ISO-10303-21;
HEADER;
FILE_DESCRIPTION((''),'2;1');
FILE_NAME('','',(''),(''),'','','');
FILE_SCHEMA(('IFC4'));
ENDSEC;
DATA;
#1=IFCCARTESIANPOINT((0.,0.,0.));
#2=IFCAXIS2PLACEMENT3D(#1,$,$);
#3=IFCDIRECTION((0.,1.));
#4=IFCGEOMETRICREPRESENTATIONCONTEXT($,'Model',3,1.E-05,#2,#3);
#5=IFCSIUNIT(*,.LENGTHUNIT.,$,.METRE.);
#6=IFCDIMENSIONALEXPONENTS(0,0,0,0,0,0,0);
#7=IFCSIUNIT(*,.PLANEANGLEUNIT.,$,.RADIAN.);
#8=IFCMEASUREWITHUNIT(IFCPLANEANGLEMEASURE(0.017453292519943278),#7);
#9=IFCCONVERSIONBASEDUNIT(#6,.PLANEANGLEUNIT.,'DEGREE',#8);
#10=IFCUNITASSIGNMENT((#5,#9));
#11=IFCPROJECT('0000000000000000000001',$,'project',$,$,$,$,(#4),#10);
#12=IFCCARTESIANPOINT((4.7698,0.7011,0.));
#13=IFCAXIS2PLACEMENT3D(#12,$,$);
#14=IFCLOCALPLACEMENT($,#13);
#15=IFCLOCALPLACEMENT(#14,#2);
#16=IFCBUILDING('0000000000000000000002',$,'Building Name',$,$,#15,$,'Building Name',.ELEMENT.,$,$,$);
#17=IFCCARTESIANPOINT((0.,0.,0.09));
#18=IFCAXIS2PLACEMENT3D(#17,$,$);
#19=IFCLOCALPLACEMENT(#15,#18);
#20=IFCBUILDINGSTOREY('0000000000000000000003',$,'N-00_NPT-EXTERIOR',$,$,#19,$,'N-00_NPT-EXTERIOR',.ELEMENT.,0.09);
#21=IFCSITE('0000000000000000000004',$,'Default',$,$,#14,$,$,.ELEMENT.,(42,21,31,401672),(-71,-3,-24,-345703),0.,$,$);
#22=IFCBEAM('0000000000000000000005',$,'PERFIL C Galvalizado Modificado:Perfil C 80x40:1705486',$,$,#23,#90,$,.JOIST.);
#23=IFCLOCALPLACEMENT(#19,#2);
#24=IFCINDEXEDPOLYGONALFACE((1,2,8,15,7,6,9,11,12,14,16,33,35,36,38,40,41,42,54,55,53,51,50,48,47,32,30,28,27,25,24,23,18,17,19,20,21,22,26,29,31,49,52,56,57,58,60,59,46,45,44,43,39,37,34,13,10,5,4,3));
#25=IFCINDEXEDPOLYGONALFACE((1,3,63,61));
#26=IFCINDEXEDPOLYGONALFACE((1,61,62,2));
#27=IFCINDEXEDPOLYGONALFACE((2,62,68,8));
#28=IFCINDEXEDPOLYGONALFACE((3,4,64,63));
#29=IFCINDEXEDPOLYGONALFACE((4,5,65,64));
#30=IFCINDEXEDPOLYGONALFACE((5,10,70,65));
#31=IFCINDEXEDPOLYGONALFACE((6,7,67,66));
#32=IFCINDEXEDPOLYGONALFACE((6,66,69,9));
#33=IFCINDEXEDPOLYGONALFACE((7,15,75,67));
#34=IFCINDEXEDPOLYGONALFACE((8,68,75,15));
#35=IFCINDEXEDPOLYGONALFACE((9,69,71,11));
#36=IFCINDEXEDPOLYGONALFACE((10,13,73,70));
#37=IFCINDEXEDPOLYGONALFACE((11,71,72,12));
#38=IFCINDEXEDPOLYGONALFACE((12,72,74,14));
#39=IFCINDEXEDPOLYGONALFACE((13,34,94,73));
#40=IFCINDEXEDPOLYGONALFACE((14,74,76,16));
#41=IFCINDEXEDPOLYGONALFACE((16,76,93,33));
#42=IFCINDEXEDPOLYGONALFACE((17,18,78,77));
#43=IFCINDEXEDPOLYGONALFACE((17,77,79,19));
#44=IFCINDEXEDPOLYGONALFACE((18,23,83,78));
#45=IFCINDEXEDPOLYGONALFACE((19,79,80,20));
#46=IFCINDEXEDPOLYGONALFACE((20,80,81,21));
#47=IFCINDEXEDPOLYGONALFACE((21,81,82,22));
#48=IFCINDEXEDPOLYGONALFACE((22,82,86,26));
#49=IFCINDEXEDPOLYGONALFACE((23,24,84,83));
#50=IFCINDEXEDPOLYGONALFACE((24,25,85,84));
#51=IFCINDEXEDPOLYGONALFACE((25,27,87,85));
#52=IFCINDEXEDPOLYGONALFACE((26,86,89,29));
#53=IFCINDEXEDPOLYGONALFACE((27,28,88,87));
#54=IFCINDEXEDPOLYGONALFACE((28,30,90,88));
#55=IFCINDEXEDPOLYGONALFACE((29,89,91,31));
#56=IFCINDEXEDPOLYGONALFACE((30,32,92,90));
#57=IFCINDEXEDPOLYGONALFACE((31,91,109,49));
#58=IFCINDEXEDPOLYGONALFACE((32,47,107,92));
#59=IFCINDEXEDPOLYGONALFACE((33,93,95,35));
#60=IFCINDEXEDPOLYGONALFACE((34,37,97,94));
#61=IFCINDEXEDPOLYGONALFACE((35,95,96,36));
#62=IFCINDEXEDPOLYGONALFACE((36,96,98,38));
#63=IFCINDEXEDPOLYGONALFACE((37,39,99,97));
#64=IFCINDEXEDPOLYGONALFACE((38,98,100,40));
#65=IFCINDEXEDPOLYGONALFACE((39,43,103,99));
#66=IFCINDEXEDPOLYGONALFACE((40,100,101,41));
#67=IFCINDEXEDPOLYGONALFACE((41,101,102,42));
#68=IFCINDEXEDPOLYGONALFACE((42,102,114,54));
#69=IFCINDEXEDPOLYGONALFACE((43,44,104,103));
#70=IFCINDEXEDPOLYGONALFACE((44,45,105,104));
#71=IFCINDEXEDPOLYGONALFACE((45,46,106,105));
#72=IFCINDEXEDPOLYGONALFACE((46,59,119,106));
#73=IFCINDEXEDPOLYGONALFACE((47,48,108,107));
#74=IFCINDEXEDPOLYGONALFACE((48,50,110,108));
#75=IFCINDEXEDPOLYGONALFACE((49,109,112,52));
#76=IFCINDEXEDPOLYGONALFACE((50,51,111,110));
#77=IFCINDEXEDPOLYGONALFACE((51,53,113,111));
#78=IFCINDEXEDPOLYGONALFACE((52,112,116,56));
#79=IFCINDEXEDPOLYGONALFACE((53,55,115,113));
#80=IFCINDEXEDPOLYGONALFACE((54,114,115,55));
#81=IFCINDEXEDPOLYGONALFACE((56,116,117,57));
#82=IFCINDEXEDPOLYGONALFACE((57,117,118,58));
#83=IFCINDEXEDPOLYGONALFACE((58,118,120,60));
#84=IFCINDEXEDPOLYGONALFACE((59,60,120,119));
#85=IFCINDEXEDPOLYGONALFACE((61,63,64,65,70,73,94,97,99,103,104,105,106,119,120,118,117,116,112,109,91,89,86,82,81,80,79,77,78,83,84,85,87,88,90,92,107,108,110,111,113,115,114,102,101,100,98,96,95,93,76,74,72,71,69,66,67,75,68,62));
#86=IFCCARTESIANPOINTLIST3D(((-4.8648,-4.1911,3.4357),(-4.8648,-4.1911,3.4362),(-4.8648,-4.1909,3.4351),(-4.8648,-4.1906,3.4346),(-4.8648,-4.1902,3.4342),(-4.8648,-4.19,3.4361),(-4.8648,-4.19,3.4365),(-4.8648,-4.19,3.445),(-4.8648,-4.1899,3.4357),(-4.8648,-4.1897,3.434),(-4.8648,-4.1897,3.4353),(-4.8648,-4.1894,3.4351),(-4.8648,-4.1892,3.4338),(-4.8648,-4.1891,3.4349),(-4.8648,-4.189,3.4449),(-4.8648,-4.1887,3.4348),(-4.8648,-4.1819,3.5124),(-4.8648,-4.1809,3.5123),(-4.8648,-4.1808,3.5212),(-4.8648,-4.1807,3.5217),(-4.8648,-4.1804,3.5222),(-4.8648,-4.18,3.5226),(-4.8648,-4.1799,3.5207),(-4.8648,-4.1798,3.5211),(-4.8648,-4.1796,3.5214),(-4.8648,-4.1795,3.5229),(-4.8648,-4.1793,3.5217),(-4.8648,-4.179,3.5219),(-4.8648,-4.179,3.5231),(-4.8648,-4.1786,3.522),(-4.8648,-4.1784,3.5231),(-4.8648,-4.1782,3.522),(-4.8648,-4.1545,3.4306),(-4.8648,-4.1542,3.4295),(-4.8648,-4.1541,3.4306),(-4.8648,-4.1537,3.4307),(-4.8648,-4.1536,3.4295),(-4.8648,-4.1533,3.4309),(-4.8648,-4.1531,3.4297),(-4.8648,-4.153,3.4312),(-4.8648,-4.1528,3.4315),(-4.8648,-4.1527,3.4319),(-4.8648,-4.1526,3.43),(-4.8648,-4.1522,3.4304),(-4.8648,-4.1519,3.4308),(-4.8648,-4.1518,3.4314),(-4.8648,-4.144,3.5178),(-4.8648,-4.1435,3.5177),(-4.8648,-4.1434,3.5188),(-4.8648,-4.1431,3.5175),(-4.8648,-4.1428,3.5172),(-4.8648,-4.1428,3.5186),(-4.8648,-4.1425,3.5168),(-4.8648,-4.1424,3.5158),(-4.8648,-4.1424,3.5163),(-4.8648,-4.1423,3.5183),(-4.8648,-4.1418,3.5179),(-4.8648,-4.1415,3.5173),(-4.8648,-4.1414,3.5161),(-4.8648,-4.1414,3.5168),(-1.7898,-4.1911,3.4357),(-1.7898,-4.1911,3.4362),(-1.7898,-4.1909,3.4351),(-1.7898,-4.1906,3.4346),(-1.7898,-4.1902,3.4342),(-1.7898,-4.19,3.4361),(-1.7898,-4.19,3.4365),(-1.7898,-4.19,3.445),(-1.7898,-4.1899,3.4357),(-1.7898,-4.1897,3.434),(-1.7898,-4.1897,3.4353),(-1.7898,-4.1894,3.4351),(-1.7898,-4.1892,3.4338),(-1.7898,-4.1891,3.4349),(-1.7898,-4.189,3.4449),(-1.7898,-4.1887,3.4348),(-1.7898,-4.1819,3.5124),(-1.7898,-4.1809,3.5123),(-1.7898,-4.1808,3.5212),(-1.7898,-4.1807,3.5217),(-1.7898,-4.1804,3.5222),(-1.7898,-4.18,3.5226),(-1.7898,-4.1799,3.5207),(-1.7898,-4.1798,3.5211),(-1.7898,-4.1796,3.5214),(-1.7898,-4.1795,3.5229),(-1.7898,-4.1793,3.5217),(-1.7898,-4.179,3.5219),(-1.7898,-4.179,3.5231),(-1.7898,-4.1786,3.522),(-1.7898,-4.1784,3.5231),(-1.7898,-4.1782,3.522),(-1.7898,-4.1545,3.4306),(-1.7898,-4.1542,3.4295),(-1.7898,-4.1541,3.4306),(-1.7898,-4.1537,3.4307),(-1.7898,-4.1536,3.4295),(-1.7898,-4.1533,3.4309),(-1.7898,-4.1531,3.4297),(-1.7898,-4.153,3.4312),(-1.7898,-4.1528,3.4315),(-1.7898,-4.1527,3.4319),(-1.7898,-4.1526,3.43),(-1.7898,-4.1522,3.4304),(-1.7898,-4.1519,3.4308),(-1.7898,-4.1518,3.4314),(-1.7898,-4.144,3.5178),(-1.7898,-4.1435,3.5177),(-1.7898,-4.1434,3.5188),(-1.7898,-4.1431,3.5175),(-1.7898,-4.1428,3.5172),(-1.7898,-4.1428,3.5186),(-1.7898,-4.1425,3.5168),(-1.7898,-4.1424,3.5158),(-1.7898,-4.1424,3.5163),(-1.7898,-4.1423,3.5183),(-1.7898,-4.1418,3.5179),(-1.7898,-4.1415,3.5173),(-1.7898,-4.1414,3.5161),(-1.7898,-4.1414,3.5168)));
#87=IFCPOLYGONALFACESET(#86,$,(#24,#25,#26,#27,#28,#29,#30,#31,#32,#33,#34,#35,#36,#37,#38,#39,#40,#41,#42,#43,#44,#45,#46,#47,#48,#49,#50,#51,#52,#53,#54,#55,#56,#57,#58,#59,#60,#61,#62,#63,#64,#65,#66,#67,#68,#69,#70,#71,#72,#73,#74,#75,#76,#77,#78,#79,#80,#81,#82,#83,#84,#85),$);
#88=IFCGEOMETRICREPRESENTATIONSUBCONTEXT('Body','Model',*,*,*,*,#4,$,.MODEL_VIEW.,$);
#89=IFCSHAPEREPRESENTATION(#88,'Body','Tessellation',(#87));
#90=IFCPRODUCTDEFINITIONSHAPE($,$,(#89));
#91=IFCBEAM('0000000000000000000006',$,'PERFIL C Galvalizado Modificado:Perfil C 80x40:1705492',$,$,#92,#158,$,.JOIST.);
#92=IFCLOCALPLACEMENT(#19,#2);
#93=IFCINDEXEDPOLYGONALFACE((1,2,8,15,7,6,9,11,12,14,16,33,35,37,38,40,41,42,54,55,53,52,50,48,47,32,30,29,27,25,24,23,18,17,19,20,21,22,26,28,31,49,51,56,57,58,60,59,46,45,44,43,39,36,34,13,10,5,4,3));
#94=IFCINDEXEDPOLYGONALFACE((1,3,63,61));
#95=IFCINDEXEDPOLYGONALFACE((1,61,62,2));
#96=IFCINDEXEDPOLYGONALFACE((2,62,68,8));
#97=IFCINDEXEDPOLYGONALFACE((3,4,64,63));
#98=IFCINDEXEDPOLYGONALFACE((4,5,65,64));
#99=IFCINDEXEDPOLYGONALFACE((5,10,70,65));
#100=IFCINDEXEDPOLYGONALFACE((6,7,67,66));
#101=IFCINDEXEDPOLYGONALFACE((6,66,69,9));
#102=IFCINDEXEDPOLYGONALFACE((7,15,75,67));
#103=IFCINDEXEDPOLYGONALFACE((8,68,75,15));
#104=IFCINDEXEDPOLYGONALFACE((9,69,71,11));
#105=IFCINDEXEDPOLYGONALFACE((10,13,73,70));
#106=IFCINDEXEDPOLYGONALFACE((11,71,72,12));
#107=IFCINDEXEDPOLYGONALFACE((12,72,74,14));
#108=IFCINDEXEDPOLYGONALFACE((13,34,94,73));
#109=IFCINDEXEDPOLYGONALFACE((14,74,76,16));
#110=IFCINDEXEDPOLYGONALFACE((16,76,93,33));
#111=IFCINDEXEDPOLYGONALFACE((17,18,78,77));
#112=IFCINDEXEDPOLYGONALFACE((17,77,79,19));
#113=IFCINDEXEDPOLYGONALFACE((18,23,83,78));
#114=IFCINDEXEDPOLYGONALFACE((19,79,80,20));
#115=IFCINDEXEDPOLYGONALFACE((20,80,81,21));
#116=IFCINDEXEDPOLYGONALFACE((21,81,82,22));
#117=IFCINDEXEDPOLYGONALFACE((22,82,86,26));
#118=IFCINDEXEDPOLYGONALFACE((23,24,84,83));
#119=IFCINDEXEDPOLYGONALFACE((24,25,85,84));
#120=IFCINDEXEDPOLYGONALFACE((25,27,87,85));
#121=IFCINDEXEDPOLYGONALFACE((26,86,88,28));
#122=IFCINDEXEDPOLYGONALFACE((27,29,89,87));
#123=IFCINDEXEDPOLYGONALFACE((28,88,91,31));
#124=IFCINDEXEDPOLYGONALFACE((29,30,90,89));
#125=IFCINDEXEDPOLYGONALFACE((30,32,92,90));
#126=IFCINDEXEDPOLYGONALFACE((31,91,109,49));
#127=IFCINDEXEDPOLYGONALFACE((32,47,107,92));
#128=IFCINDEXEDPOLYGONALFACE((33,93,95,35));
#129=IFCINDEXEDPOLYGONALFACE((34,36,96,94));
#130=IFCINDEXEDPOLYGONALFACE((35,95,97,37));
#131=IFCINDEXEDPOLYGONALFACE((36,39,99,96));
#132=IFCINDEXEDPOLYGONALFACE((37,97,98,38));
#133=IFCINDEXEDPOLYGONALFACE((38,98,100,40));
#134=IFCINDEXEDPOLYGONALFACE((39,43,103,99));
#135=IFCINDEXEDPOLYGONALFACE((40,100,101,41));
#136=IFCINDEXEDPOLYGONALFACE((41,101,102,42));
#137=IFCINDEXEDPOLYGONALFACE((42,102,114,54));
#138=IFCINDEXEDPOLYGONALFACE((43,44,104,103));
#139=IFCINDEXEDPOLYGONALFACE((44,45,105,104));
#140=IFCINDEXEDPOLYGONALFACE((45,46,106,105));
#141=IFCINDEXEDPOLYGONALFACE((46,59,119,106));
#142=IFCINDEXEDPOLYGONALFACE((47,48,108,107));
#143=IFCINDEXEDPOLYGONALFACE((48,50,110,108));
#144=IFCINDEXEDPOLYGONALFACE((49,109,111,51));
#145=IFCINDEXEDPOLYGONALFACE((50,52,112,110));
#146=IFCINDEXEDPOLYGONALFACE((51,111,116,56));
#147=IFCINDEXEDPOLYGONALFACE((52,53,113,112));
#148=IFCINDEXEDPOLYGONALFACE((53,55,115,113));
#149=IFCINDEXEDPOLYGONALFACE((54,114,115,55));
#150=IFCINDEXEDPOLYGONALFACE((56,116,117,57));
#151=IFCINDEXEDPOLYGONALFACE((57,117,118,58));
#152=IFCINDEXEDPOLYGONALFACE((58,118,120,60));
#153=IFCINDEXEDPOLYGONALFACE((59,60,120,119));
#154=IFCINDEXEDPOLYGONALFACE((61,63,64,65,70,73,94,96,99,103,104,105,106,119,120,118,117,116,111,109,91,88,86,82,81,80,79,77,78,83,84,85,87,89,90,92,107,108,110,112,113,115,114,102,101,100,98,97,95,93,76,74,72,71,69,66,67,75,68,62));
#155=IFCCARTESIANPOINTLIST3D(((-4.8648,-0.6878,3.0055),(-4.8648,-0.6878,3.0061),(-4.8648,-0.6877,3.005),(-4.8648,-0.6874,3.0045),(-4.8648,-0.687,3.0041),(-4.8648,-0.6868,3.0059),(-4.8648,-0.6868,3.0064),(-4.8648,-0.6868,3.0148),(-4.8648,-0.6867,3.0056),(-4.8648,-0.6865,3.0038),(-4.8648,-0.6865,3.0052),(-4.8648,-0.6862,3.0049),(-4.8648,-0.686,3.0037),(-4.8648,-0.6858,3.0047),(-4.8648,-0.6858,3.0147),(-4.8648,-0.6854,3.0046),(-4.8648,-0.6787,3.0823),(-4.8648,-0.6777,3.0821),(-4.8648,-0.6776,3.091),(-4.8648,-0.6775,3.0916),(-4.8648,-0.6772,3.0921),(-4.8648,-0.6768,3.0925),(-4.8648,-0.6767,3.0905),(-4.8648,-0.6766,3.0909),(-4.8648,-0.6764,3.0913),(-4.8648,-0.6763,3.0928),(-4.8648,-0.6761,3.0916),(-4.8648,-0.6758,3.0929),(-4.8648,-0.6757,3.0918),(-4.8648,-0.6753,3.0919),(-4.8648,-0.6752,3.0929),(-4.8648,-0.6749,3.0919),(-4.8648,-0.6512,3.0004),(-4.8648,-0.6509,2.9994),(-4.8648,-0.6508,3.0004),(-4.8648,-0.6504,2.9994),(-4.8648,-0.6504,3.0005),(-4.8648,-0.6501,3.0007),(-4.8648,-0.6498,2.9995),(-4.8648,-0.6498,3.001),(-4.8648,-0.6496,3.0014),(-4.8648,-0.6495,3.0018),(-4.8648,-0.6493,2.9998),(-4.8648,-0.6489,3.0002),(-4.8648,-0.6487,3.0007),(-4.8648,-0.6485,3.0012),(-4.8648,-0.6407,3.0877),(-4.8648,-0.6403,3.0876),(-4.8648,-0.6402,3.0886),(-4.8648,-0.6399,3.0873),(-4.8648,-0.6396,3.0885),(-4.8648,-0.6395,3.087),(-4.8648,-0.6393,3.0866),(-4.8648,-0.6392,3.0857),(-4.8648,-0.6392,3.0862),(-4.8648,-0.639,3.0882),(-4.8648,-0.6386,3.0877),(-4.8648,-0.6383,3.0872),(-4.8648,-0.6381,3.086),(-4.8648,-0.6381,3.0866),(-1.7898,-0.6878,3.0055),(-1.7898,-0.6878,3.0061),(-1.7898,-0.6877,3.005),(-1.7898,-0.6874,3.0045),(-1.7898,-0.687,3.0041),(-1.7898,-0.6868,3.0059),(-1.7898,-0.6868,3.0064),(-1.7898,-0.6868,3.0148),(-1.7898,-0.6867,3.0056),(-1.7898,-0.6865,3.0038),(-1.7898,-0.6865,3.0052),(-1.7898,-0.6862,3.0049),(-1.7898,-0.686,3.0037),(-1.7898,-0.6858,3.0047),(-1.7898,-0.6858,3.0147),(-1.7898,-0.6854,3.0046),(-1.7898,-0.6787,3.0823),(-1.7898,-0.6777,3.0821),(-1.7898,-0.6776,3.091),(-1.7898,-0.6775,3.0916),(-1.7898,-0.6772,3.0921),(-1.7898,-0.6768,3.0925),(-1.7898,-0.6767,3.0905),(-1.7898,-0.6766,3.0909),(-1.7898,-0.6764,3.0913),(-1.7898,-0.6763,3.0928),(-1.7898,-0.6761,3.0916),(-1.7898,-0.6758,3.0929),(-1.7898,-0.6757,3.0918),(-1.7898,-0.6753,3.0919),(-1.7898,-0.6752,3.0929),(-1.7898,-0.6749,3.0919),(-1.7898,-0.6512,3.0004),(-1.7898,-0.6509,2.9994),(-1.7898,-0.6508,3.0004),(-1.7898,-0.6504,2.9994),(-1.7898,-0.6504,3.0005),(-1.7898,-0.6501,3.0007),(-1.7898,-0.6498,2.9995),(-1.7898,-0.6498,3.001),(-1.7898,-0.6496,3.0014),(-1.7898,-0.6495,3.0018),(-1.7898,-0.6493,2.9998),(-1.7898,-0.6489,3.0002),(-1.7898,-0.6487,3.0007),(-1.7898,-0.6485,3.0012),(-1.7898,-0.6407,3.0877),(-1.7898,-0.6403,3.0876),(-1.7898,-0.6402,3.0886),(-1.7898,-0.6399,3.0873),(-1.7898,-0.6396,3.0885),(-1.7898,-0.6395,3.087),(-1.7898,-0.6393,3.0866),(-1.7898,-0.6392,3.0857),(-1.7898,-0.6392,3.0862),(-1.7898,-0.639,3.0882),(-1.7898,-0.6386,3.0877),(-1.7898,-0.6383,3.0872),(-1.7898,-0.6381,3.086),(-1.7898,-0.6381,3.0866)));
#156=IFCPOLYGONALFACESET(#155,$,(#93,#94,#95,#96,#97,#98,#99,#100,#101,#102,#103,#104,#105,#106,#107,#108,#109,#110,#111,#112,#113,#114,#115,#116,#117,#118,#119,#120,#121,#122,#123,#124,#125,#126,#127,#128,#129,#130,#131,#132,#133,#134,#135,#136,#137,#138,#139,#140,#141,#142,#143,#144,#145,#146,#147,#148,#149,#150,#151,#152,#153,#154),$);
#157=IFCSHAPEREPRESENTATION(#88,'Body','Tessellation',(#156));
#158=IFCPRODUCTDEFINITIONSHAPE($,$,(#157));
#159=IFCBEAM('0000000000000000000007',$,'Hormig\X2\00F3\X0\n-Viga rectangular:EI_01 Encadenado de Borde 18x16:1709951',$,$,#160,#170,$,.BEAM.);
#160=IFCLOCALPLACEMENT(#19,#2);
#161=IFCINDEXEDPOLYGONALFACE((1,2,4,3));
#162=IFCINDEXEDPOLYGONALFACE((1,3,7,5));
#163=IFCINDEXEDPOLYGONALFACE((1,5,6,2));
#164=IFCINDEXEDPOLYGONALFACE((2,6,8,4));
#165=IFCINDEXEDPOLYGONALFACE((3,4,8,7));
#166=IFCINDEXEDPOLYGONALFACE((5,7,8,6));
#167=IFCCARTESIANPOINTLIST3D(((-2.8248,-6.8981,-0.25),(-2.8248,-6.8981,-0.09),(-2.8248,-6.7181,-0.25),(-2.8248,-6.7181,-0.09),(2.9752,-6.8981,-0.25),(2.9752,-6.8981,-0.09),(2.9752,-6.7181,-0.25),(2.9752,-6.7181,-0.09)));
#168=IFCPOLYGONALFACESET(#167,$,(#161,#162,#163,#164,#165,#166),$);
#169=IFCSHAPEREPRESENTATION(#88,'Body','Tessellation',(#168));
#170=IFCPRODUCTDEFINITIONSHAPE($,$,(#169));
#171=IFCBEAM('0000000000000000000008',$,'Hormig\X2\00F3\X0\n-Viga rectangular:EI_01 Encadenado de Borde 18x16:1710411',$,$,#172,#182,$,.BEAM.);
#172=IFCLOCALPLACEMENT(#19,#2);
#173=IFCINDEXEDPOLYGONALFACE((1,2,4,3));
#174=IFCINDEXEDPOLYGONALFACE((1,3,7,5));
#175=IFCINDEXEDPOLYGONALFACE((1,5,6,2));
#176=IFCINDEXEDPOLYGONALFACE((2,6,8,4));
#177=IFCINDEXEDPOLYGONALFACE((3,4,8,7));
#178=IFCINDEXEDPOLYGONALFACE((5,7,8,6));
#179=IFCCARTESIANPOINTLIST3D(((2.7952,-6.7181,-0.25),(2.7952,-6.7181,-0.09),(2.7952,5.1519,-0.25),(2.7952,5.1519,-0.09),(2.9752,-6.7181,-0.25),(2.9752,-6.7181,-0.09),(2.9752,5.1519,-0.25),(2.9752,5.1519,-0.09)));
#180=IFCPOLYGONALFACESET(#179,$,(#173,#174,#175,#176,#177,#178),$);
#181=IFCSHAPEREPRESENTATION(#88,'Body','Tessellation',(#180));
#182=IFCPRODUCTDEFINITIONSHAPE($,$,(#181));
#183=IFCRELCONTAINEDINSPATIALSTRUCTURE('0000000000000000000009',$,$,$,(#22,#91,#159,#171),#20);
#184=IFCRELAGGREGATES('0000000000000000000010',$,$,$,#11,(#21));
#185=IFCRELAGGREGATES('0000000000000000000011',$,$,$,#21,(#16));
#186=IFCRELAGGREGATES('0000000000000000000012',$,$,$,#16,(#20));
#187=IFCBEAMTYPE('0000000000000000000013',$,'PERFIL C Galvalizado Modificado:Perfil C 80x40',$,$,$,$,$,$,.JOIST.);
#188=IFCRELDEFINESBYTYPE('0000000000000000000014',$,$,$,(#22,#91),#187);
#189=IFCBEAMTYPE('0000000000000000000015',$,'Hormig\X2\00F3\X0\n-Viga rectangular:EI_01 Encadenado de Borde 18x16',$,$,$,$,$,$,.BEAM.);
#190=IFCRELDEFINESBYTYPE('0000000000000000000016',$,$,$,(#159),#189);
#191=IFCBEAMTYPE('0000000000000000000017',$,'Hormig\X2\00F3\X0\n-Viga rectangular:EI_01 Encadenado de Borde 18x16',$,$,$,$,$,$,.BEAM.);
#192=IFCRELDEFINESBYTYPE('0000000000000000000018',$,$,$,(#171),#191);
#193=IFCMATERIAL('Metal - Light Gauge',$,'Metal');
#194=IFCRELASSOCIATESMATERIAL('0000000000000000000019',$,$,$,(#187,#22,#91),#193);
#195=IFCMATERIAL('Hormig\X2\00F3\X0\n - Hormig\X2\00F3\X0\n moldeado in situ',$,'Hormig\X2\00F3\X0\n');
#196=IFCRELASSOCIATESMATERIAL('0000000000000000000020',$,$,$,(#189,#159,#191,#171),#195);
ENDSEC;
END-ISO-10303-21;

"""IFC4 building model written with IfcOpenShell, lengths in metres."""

from ifc_helpers import new_model, entity, si_unit, converted_unit, direction, frame, origin, place, context, subcontext, project, spatial, line, arc, indexed_curve, outline, extrude, source, transform, mapped, material, type_object, type_shapes, element, save


model = new_model("IFC4")

# Units and contexts
model_context = context("Model", 3, precision=1e-05, world=origin(), true_north=direction((0.0, 1.0)))
body_context = subcontext(model_context, "Body", "Model", "MODEL_VIEW")
ifc_project = project(units=[si_unit("LENGTHUNIT", "METRE"), converted_unit("PLANEANGLEUNIT", "DEGREE", entity("IfcPlaneAngleMeasure", 0.017453292519943278), si_unit("PLANEANGLEUNIT", "RADIAN"), dimensions=[0, 0, 0, 0, 0, 0, 0])], contexts=[model_context])

# Site, building, storey
site_placement = place(None, frame((4.7698, 0.7011, 0.0)))
site = spatial("IfcSite", under=ifc_project, at=site_placement, Name="Default", CompositionType="ELEMENT", RefLatitude=(42, 21, 31, 401672), RefLongitude=(-71, -3, -24, -345703), RefElevation=0.0)
building_placement = place(site_placement, origin())
building = spatial("IfcBuilding", under=site, at=building_placement, Name="Building Name", LongName="Building Name", CompositionType="ELEMENT")
storey_placement = place(building_placement, frame((0.0, 0.0, 0.09)))
storey = spatial("IfcBuildingStorey", under=building, at=storey_placement, Name="N-00_NPT-EXTERIOR", LongName="N-00_NPT-EXTERIOR", CompositionType="ELEMENT", Elevation=0.09)

# Beams
ifc_material_1 = material(Name="Hormigón - Hormigón moldeado in situ", Category="Hormigón")
ifc_material_2 = material(Name="Metal - Light Gauge", Category="Metal")
beam_type_1 = type_object("IfcBeamType", Name="PERFIL C Galvalizado Modificado:Perfil C 80x40", PredefinedType="JOIST", material=ifc_material_2)
shared_shape_1 = source(origin(), body_context, "Body", "SweptSolid", [
    extrude(outline(indexed_curve([(-0.0428, -0.0161), (-0.034, -0.0161), (-0.034, -0.0151), (-0.0424, -0.0151), (-0.0435, -0.0146), (-0.044, -0.0135), (-0.044, 0.021), (-0.0435, 0.0222), (-0.0422, 0.0227), (0.0424, 0.0227), (0.0435, 0.0223), (0.0439, 0.0212), (0.0439, -0.0133), (0.0435, -0.0144), (0.0424, -0.0149), (0.0339, -0.0149), (0.0339, -0.0159), (0.0428, -0.0159), (0.0443, -0.0152), (0.0449, -0.0137), (0.0449, 0.0216), (0.0443, 0.0231), (0.0428, 0.0237), (-0.0426, 0.0237), (-0.0443, 0.023), (-0.045, 0.0214), (-0.045, -0.0139), (-0.0443, -0.0154)], segments=[line(1, 2, 3, 4), arc(4, 5, 6), line(6, 7), arc(7, 8, 9), line(9, 10), arc(10, 11, 12), line(12, 13), arc(13, 14, 15), line(15, 16, 17, 18), arc(18, 19, 20), line(20, 21), arc(21, 22, 23), line(23, 24), arc(24, 25, 26), line(26, 27), arc(27, 28, 1)], self_intersect=False)), frame((-1.5375, -0.0037, 0.0), z_axis=(1.0, 0.0, 0.0), x_axis=(0.0, 0.0, -1.0)), (0.0, 0.0, 1.0), 3.075),
])
type_shapes(beam_type_1, [shared_shape_1])
for number, where, z_axis, x_axis, name in (
    (1, (-3.3273, -4.1664, 3.4763), (0.0, 0.121869, 0.992546), (1.0, 0.0, 0.0), "PERFIL C Galvalizado Modificado:Perfil C 80x40:1705486"),
    (2, (-3.3273, -0.6632, 3.0462), (0.0, 0.121869, 0.992546), (1.0, 0.0, 0.0), "PERFIL C Galvalizado Modificado:Perfil C 80x40:1705492"),
):
    element("IfcBeam", number, at=place(storey_placement, frame(where, z_axis=z_axis, x_axis=x_axis)), inside=storey, type_object=beam_type_1, material=ifc_material_2, Name=name, PredefinedType="JOIST", context=body_context, shape_type="MappedRepresentation", body=[
        mapped(shared_shape_1, transform((0.0, 0.0, 0.0), scale=1.0)),
    ])
beam_type_2 = type_object("IfcBeamType", Name="Hormigón-Viga rectangular:EI_01 Encadenado de Borde 18x16", PredefinedType="BEAM", material=ifc_material_1)
shared_shape_2 = source(origin(), body_context, "Body", "SweptSolid", [
    extrude(outline(indexed_curve([(-0.08, -0.09), (0.08, -0.09), (0.08, 0.09), (-0.08, 0.09), (-0.08, -0.09)], self_intersect=False)), frame((2.9752, -6.8081, -0.08), z_axis=(-1.0, 0.0, 0.0), x_axis=(0.0, 0.0, -1.0)), (0.0, 0.0, 1.0), 5.8),
])
type_shapes(beam_type_2, [shared_shape_2])
beam_1_placement = place(storey_placement, frame((0.0, 0.0, -0.09)))
element("IfcBeam", 3, at=beam_1_placement, inside=storey, type_object=beam_type_2, material=ifc_material_1, Name="Hormigón-Viga rectangular:EI_01 Encadenado de Borde 18x16:1709951", PredefinedType="BEAM", context=body_context, shape_type="MappedRepresentation", body=[
    mapped(shared_shape_2, transform((0.0, 0.0, 0.0), scale=1.0)),
])
beam_type_3 = type_object("IfcBeamType", Name="Hormigón-Viga rectangular:EI_01 Encadenado de Borde 18x16", PredefinedType="BEAM", material=ifc_material_1)
shared_shape_3 = source(origin(), body_context, "Body", "SweptSolid", [
    extrude(outline(indexed_curve([(-0.09, -0.08), (0.09, -0.08), (0.09, 0.08), (-0.09, 0.08), (-0.09, -0.08)], self_intersect=False)), frame((2.8852, -6.7181, -0.08), z_axis=(0.0, 1.0, 0.0), x_axis=(-1.0, 0.0, 0.0)), (0.0, 0.0, 1.0), 11.87),
])
type_shapes(beam_type_3, [shared_shape_3])
beam_2_placement = place(storey_placement, frame((0.0, 0.0, -0.09)))
element("IfcBeam", 4, at=beam_2_placement, inside=storey, type_object=beam_type_3, material=ifc_material_1, Name="Hormigón-Viga rectangular:EI_01 Encadenado de Borde 18x16:1710411", PredefinedType="BEAM", context=body_context, shape_type="MappedRepresentation", body=[
    mapped(shared_shape_3, transform((0.0, 0.0, 0.0), scale=1.0)),
])

save(model, "model.ifc")
